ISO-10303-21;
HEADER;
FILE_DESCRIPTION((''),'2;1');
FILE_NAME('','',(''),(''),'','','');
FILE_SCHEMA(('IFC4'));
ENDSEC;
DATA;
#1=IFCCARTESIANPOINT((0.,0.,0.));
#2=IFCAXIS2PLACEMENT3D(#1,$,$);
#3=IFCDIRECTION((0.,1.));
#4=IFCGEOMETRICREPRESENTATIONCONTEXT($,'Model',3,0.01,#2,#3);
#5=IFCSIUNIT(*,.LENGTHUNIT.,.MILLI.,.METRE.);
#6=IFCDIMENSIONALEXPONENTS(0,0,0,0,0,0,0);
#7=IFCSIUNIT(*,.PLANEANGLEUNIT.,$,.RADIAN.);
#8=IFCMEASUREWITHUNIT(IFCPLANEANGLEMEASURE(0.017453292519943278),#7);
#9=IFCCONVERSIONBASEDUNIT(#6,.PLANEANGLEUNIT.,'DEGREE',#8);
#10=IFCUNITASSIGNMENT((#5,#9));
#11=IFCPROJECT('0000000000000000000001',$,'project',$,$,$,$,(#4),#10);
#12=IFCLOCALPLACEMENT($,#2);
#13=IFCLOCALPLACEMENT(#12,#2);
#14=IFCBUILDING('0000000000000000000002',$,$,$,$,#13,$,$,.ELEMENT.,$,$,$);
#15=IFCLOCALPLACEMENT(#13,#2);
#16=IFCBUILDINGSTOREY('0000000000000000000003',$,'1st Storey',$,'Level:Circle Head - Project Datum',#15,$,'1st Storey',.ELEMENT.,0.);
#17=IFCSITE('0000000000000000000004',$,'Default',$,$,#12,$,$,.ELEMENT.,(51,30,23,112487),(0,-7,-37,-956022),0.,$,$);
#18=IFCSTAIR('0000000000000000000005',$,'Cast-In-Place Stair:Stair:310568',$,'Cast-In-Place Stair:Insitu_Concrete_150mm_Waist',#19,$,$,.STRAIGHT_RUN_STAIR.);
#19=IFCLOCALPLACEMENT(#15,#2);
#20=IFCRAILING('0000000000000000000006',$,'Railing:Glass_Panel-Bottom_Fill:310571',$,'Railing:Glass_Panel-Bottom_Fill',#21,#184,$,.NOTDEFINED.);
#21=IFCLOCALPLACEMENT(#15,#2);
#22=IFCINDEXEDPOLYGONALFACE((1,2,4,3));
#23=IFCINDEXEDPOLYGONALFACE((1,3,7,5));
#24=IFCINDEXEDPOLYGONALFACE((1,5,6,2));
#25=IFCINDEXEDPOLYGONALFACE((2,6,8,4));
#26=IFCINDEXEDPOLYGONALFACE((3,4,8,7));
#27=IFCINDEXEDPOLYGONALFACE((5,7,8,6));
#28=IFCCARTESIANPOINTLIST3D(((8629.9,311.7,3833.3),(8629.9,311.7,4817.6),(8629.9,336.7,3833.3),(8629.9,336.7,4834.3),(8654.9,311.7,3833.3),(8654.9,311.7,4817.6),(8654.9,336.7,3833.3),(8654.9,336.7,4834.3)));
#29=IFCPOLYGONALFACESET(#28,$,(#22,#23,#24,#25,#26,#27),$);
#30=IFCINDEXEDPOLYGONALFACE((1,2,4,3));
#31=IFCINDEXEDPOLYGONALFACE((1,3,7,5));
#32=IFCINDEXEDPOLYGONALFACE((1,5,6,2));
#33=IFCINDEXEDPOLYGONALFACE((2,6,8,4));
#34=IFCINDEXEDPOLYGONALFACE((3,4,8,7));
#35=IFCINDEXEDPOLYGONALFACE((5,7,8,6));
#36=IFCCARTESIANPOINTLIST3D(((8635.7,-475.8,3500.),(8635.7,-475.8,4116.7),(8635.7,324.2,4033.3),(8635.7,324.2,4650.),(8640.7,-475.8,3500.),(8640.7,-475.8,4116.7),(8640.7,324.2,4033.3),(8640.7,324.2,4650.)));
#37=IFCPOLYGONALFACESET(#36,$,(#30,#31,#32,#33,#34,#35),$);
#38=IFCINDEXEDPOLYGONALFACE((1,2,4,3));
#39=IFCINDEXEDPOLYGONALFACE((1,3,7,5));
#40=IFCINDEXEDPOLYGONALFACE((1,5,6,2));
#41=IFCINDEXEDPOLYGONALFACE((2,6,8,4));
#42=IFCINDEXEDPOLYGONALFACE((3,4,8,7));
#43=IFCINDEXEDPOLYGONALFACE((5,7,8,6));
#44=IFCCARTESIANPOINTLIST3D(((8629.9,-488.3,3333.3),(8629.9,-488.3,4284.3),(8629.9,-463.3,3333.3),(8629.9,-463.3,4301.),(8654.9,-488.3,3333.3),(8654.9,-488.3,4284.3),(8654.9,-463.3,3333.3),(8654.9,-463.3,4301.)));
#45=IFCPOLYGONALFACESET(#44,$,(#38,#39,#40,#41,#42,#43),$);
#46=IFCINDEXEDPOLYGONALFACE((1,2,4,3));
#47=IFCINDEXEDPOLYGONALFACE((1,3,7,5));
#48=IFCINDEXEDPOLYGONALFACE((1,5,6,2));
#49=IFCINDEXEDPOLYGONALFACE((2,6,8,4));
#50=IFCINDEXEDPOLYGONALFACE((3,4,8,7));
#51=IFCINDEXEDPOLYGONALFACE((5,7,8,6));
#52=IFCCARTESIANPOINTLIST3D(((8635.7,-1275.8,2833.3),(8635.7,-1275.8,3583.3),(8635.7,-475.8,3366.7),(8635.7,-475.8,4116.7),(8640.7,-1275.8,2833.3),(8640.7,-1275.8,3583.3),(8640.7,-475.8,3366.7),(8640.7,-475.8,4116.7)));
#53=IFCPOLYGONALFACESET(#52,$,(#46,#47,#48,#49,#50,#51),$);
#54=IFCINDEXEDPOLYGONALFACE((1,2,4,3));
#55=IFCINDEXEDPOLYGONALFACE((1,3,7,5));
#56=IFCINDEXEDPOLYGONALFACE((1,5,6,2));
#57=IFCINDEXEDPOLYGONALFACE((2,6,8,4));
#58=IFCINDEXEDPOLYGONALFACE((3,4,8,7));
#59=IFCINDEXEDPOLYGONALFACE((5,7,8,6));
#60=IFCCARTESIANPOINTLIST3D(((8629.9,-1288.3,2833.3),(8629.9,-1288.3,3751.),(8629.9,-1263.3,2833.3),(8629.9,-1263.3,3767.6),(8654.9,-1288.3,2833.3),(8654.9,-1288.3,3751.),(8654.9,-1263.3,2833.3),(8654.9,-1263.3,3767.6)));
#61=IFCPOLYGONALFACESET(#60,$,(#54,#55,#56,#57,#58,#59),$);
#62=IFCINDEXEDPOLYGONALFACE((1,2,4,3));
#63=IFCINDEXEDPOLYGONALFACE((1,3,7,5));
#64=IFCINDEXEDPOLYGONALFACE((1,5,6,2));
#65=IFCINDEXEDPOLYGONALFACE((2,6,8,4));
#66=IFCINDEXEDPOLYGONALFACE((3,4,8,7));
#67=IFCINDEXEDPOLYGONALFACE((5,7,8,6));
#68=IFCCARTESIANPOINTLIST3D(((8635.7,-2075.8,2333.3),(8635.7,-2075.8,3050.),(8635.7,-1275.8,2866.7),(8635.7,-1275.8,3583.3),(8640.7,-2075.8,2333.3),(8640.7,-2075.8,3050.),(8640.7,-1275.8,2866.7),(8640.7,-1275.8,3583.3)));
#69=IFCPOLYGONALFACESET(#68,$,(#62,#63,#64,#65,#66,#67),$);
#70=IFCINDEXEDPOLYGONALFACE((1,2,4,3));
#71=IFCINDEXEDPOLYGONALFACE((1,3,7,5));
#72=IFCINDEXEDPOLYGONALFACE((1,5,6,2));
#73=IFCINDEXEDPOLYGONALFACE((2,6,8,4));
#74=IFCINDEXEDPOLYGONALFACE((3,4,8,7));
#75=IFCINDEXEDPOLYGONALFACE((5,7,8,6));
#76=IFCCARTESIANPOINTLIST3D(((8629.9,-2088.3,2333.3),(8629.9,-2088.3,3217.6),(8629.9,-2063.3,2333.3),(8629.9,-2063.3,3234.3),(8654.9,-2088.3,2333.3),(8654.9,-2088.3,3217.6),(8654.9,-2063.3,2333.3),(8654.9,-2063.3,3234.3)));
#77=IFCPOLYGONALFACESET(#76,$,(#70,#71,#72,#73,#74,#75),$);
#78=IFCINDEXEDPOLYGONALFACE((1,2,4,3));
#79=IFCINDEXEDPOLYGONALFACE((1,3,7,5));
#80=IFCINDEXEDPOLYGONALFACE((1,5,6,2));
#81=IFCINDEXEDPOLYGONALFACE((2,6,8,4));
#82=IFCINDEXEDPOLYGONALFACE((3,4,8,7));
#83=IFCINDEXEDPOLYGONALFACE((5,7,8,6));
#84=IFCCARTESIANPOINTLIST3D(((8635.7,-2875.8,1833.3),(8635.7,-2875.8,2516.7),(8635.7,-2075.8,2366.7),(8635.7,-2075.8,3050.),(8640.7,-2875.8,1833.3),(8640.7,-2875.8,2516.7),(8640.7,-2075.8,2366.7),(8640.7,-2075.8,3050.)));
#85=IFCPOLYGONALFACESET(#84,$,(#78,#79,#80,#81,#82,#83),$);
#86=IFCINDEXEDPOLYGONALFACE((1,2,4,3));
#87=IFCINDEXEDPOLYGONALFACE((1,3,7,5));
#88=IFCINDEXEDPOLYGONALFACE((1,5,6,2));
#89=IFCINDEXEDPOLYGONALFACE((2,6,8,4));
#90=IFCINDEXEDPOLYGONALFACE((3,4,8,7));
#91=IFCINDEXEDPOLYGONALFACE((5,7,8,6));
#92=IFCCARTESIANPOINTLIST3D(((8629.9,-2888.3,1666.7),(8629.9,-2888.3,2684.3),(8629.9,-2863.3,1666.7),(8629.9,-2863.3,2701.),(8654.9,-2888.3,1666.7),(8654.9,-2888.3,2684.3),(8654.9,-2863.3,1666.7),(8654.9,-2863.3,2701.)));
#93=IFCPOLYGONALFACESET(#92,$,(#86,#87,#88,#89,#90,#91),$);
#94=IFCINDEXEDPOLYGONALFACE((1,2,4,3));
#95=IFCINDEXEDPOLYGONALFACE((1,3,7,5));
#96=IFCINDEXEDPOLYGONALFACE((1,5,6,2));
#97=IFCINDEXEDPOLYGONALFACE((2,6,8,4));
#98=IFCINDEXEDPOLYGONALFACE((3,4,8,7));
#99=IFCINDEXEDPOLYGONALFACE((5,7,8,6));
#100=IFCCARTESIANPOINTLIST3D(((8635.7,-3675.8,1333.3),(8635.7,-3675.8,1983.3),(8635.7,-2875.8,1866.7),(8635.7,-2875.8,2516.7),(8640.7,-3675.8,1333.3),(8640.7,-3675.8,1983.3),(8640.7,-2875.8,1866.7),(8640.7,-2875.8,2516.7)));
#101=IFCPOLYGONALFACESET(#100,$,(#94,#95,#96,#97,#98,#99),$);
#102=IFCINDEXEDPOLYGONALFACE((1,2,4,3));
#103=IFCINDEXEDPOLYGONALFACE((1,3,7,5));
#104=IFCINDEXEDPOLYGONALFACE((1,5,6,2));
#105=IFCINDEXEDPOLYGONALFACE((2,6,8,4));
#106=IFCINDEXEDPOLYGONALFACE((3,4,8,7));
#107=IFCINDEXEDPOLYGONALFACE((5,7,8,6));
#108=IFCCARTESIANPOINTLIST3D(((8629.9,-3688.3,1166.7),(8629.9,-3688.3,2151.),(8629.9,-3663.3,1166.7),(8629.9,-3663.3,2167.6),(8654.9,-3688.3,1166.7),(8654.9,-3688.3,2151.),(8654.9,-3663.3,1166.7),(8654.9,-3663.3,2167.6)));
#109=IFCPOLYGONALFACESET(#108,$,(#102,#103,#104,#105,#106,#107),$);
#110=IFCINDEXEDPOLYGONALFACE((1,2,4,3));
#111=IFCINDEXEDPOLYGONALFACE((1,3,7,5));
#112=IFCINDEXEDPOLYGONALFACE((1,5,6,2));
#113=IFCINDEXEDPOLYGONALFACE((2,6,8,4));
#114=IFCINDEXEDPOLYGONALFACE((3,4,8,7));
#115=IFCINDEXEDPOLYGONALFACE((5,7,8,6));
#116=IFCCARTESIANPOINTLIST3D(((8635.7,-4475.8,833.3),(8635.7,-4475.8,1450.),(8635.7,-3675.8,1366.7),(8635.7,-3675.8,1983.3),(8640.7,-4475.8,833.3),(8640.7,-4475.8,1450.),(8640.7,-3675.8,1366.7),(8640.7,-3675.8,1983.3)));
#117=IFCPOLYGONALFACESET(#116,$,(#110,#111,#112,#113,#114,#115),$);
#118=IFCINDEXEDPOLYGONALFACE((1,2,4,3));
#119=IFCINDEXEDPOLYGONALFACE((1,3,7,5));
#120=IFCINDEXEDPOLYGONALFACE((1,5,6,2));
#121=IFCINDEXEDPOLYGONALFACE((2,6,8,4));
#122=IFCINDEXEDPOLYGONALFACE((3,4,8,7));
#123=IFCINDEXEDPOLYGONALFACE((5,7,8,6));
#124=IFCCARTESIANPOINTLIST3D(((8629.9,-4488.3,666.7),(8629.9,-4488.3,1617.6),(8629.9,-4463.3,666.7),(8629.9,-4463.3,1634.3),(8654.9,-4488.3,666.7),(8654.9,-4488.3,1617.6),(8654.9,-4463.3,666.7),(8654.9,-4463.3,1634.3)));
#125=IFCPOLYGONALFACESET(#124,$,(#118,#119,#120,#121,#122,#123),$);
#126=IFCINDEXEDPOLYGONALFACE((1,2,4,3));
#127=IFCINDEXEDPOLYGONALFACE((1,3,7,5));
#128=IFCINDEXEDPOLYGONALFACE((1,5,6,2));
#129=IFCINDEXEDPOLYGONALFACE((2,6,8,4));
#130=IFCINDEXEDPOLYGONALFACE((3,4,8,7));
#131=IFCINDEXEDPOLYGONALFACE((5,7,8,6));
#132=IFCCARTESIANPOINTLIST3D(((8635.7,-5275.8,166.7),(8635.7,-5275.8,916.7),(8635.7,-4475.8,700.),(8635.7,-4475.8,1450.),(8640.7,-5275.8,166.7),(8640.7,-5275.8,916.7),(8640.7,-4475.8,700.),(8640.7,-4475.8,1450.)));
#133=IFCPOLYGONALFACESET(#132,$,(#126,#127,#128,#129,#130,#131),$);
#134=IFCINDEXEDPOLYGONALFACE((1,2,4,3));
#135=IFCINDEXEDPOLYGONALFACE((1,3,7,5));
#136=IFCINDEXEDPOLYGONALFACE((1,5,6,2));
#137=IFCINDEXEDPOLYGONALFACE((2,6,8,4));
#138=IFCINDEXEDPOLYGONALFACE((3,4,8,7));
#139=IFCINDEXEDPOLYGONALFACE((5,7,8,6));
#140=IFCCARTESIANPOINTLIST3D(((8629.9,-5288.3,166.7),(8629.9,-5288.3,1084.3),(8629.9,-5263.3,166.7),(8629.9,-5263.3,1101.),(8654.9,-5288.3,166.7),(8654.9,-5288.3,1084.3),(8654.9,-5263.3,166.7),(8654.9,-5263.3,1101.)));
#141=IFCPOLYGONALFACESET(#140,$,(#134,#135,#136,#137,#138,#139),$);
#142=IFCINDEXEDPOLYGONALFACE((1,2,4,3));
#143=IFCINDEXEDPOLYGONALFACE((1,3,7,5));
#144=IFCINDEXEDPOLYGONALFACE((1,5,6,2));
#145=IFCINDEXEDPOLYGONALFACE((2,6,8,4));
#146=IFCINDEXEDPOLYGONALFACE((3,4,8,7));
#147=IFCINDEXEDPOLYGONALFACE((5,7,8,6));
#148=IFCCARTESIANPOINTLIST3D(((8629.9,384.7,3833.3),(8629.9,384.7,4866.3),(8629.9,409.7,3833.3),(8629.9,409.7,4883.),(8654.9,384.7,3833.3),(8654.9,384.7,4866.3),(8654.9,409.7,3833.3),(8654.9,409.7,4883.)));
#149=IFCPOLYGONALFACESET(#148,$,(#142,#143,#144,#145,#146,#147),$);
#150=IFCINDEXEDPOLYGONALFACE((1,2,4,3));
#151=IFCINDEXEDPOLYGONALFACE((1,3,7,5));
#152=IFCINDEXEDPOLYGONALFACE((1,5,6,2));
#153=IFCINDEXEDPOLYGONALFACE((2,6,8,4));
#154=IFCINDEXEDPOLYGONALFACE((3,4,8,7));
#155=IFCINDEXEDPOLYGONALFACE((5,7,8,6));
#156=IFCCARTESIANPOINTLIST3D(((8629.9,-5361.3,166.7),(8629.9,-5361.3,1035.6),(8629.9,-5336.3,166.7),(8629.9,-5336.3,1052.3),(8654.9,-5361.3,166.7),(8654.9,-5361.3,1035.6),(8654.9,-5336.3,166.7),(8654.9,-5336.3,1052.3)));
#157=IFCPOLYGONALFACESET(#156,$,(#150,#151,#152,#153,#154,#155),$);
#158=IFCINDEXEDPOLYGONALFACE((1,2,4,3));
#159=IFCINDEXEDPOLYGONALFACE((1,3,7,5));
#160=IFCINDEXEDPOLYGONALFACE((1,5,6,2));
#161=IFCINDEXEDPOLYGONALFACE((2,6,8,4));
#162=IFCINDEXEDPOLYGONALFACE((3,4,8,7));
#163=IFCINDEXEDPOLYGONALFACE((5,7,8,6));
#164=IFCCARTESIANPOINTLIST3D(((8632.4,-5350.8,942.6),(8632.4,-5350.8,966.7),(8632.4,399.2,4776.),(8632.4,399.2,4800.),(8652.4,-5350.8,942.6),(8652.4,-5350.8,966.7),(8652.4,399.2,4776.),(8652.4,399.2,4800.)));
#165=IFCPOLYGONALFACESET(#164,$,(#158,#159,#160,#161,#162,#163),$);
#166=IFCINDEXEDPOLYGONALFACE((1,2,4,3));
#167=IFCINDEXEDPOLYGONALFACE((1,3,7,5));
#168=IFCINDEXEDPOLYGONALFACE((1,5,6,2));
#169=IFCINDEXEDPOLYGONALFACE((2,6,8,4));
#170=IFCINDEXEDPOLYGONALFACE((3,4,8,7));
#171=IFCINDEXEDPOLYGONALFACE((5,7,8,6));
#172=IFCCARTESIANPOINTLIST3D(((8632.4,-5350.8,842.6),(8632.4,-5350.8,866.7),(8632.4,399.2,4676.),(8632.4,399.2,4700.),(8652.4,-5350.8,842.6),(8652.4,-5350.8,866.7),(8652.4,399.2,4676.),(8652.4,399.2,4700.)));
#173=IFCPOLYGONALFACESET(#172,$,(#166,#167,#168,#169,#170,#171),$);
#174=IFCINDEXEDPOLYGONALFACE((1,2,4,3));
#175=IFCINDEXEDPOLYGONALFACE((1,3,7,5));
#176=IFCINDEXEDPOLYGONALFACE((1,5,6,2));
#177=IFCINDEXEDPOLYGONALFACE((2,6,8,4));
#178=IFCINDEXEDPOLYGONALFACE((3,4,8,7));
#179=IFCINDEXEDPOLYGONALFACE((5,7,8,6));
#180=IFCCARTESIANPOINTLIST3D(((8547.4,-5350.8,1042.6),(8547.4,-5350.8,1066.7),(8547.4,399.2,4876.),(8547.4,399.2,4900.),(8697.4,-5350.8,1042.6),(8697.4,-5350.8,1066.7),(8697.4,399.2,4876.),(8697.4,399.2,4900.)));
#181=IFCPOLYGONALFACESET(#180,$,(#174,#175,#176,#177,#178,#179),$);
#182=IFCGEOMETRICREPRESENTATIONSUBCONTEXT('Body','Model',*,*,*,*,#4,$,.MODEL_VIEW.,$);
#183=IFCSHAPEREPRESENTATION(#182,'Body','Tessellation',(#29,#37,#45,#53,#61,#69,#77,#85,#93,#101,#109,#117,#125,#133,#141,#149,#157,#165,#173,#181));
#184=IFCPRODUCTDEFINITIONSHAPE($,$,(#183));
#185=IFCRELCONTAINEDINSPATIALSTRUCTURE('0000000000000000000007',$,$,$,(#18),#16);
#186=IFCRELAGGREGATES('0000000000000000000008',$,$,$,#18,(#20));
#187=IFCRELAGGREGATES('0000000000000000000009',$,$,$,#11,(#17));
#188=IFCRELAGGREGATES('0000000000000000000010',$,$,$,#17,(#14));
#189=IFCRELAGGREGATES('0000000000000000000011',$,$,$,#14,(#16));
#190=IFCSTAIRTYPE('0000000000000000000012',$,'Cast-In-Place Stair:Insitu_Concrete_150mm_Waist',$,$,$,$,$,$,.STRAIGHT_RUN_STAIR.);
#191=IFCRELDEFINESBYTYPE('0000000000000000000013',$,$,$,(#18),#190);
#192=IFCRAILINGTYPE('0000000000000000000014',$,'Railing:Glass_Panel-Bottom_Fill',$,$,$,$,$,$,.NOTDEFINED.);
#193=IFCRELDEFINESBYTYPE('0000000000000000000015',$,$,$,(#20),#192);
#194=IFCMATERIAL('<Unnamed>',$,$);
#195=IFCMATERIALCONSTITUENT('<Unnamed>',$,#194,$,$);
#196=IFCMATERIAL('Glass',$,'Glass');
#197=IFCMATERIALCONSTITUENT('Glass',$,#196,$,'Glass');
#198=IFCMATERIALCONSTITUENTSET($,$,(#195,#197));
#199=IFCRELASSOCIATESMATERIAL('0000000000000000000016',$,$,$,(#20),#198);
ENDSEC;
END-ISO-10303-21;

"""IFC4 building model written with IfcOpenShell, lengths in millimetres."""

from ifc_helpers import new_model, entity, si_unit, converted_unit, direction, frame, origin, place, context, subcontext, project, spatial, indexed_curve, outline, extrude, material, constituent, constituent_set, type_object, element, aggregate, save


model = new_model("IFC4")

# Units and contexts
model_context = context("Model", 3, precision=0.01, world=origin(), true_north=direction((0.0, 1.0)))
body_context = subcontext(model_context, "Body", "Model", "MODEL_VIEW")
ifc_project = project(units=[si_unit("LENGTHUNIT", "METRE", prefix="MILLI"), converted_unit("PLANEANGLEUNIT", "DEGREE", entity("IfcPlaneAngleMeasure", 0.017453292519943278), si_unit("PLANEANGLEUNIT", "RADIAN"), dimensions=[0, 0, 0, 0, 0, 0, 0])], contexts=[model_context])

# Site, building, storey
site_placement = place(None, origin())
site = spatial("IfcSite", under=ifc_project, at=site_placement, Name="Default", CompositionType="ELEMENT", RefLatitude=(51, 30, 23, 112487), RefLongitude=(0, -7, -37, -956022), RefElevation=0.0)
building_placement = place(site_placement, origin())
building = spatial("IfcBuilding", under=site, at=building_placement, CompositionType="ELEMENT")
storey_placement = place(building_placement, origin())
storey = spatial("IfcBuildingStorey", under=building, at=storey_placement, Name="1st Storey", ObjectType="Level:Circle Head - Project Datum", LongName="1st Storey", CompositionType="ELEMENT", Elevation=0.0)

# Shared definitions
ifc_material_1 = material(Name="<Unnamed>")

# Shared definitions
stair_type_1 = type_object("IfcStairType", Name="Cast-In-Place Stair:Insitu_Concrete_150mm_Waist", PredefinedType="STRAIGHT_RUN_STAIR")

# Stair, railing
ifc_material_2 = material(Name="Glass", Category="Glass")
railing_type_1 = type_object("IfcRailingType", Name="Railing:Glass_Panel-Bottom_Fill", PredefinedType="NOTDEFINED")
stair_1_placement = place(storey_placement, origin())
stair_1 = element("IfcStair", 1, at=stair_1_placement, inside=storey, type_object=stair_type_1, Name="Cast-In-Place Stair:Stair:310568", ObjectType="Cast-In-Place Stair:Insitu_Concrete_150mm_Waist", PredefinedType="STRAIGHT_RUN_STAIR")
ifc_constituent_1 = constituent(ifc_material_1, Name="<Unnamed>")
ifc_constituent_2 = constituent(ifc_material_2, Name="Glass", Category="Glass")
ifc_constituent_set_1 = constituent_set(constituents=[ifc_constituent_1, ifc_constituent_2])
railing_1_placement = place(stair_1_placement, frame((8547.4, -5361.3, 166.7)))
railing_1 = element("IfcRailing", 2, at=railing_1_placement, type_object=railing_type_1, material=ifc_constituent_set_1, Name="Railing:Glass_Panel-Bottom_Fill:310571", ObjectType="Railing:Glass_Panel-Bottom_Fill", PredefinedType="NOTDEFINED", context=body_context, shape_type="SweptSolid", body=[
    extrude(outline(indexed_curve([(-488.0, -12.5), (496.3, -12.5), (496.3, 12.5), (-504.6, 12.5), (-488.0, -12.5)], self_intersect=False)), frame((82.5, 5685.5, 4163.0), z_axis=(1.0, 0.0, 0.0), x_axis=(0.0, 0.0, -1.0)), (0.0, 0.0, 1.0), 25.0),
    extrude(outline(indexed_curve([(-41.7, -400.0), (575.0, -400.0), (41.7, 400.0), (-575.0, 400.0), (-41.7, -400.0)], self_intersect=False)), frame((88.3, 5285.5, 3908.3), z_axis=(1.0, 0.0, 0.0), x_axis=(0.0, 0.0, -1.0)), (0.0, 0.0, 1.0), 5.0),
    extrude(outline(indexed_curve([(-471.3, -12.5), (479.6, -12.5), (479.6, 12.5), (-488.0, 12.5), (-471.3, -12.5)], self_intersect=False)), frame((82.5, 4885.5, 3646.3), z_axis=(1.0, 0.0, 0.0), x_axis=(0.0, 0.0, -1.0)), (0.0, 0.0, 1.0), 25.0),
    extrude(outline(indexed_curve([(-108.3, -400.0), (641.7, -400.0), (108.3, 400.0), (-641.7, 400.0), (-108.3, -400.0)], self_intersect=False)), frame((88.3, 4485.5, 3308.3), z_axis=(1.0, 0.0, 0.0), x_axis=(0.0, 0.0, -1.0)), (0.0, 0.0, 1.0), 5.0),
    extrude(outline(indexed_curve([(-454.6, -12.5), (463.0, -12.5), (463.0, 12.5), (-471.3, 12.5), (-454.6, -12.5)], self_intersect=False)), frame((82.5, 4085.5, 3129.6), z_axis=(1.0, 0.0, 0.0), x_axis=(0.0, 0.0, -1.0)), (0.0, 0.0, 1.0), 25.0),
    extrude(outline(indexed_curve([(-91.7, -400.0), (625.0, -400.0), (91.7, 400.0), (-625.0, 400.0), (-91.7, -400.0)], self_intersect=False)), frame((88.3, 3685.5, 2791.7), z_axis=(1.0, 0.0, 0.0), x_axis=(0.0, 0.0, -1.0)), (0.0, 0.0, 1.0), 5.0),
    extrude(outline(indexed_curve([(-438.0, -12.5), (446.3, -12.5), (446.3, 12.5), (-454.6, 12.5), (-438.0, -12.5)], self_intersect=False)), frame((82.5, 3285.5, 2613.0), z_axis=(1.0, 0.0, 0.0), x_axis=(0.0, 0.0, -1.0)), (0.0, 0.0, 1.0), 25.0),
    extrude(outline(indexed_curve([(-75.0, -400.0), (608.3, -400.0), (75.0, 400.0), (-608.3, 400.0), (-75.0, -400.0)], self_intersect=False)), frame((88.3, 2885.5, 2275.0), z_axis=(1.0, 0.0, 0.0), x_axis=(0.0, 0.0, -1.0)), (0.0, 0.0, 1.0), 5.0),
    extrude(outline(indexed_curve([(-504.6, -12.5), (513.0, -12.5), (513.0, 12.5), (-521.3, 12.5), (-504.6, -12.5)], self_intersect=False)), frame((82.5, 2485.5, 2013.0), z_axis=(1.0, 0.0, 0.0), x_axis=(0.0, 0.0, -1.0)), (0.0, 0.0, 1.0), 25.0),
    extrude(outline(indexed_curve([(-58.3, -400.0), (591.7, -400.0), (58.3, 400.0), (-591.7, 400.0), (-58.3, -400.0)], self_intersect=False)), frame((88.3, 2085.5, 1758.3), z_axis=(1.0, 0.0, 0.0), x_axis=(0.0, 0.0, -1.0)), (0.0, 0.0, 1.0), 5.0),
    extrude(outline(indexed_curve([(-488.0, -12.5), (496.3, -12.5), (496.3, 12.5), (-504.6, 12.5), (-488.0, -12.5)], self_intersect=False)), frame((82.5, 1685.5, 1496.3), z_axis=(1.0, 0.0, 0.0), x_axis=(0.0, 0.0, -1.0)), (0.0, 0.0, 1.0), 25.0),
    extrude(outline(indexed_curve([(-41.7, -400.0), (575.0, -400.0), (41.7, 400.0), (-575.0, 400.0), (-41.7, -400.0)], self_intersect=False)), frame((88.3, 1285.5, 1241.7), z_axis=(1.0, 0.0, 0.0), x_axis=(0.0, 0.0, -1.0)), (0.0, 0.0, 1.0), 5.0),
    extrude(outline(indexed_curve([(-471.3, -12.5), (479.6, -12.5), (479.6, 12.5), (-488.0, 12.5), (-471.3, -12.5)], self_intersect=False)), frame((82.5, 885.5, 979.6), z_axis=(1.0, 0.0, 0.0), x_axis=(0.0, 0.0, -1.0)), (0.0, 0.0, 1.0), 25.0),
    extrude(outline(indexed_curve([(-108.3, -400.0), (641.7, -400.0), (108.3, 400.0), (-641.7, 400.0), (-108.3, -400.0)], self_intersect=False)), frame((88.3, 485.5, 641.7), z_axis=(1.0, 0.0, 0.0), x_axis=(0.0, 0.0, -1.0)), (0.0, 0.0, 1.0), 5.0),
    extrude(outline(indexed_curve([(-454.6, -12.5), (463.0, -12.5), (463.0, 12.5), (-471.3, 12.5), (-454.6, -12.5)], self_intersect=False)), frame((82.5, 85.5, 463.0), z_axis=(1.0, 0.0, 0.0), x_axis=(0.0, 0.0, -1.0)), (0.0, 0.0, 1.0), 25.0),
    extrude(outline(indexed_curve([(-512.3, -12.5), (520.6, -12.5), (520.6, 12.5), (-529.0, 12.5), (-512.3, -12.5)], self_intersect=False)), frame((82.5, 5758.5, 4187.3), z_axis=(1.0, 0.0, 0.0), x_axis=(0.0, 0.0, -1.0)), (0.0, 0.0, 1.0), 25.0),
    extrude(outline(indexed_curve([(-430.3, -12.5), (438.6, -12.5), (438.6, 12.5), (-447.0, 12.5), (-430.3, -12.5)], self_intersect=False)), frame((82.5, 12.5, 438.6), z_axis=(1.0, 0.0, 0.0), x_axis=(0.0, 0.0, -1.0)), (0.0, 0.0, 1.0), 25.0),
    extrude(outline(indexed_curve([(-3462.0, -10.0), (3448.7, -10.0), (3462.0, 10.0), (-3448.7, 10.0), (-3462.0, -10.0)], self_intersect=False)), frame((85.0, 2885.5, 2704.6), z_axis=(1.0, 0.0, 0.0), x_axis=(0.0, 0.83205, 0.5547)), (0.0, 0.0, 1.0), 20.0),
    extrude(outline(indexed_curve([(-3462.0, -10.0), (3448.7, -10.0), (3462.0, 10.0), (-3448.7, 10.0), (-3462.0, -10.0)], self_intersect=False)), frame((85.0, 2885.5, 2604.6), z_axis=(1.0, 0.0, 0.0), x_axis=(0.0, 0.83205, 0.5547)), (0.0, 0.0, 1.0), 20.0),
    extrude(outline(indexed_curve([(-3462.0, -10.0), (3448.7, -10.0), (3462.0, 10.0), (-3448.7, 10.0), (-3462.0, -10.0)], self_intersect=False)), frame((0.0, 2885.5, 2804.6), z_axis=(1.0, 0.0, 0.0), x_axis=(0.0, 0.83205, 0.5547)), (0.0, 0.0, 1.0), 150.0),
])
aggregate(stair_1, [railing_1])

save(model, "model.ifc")
